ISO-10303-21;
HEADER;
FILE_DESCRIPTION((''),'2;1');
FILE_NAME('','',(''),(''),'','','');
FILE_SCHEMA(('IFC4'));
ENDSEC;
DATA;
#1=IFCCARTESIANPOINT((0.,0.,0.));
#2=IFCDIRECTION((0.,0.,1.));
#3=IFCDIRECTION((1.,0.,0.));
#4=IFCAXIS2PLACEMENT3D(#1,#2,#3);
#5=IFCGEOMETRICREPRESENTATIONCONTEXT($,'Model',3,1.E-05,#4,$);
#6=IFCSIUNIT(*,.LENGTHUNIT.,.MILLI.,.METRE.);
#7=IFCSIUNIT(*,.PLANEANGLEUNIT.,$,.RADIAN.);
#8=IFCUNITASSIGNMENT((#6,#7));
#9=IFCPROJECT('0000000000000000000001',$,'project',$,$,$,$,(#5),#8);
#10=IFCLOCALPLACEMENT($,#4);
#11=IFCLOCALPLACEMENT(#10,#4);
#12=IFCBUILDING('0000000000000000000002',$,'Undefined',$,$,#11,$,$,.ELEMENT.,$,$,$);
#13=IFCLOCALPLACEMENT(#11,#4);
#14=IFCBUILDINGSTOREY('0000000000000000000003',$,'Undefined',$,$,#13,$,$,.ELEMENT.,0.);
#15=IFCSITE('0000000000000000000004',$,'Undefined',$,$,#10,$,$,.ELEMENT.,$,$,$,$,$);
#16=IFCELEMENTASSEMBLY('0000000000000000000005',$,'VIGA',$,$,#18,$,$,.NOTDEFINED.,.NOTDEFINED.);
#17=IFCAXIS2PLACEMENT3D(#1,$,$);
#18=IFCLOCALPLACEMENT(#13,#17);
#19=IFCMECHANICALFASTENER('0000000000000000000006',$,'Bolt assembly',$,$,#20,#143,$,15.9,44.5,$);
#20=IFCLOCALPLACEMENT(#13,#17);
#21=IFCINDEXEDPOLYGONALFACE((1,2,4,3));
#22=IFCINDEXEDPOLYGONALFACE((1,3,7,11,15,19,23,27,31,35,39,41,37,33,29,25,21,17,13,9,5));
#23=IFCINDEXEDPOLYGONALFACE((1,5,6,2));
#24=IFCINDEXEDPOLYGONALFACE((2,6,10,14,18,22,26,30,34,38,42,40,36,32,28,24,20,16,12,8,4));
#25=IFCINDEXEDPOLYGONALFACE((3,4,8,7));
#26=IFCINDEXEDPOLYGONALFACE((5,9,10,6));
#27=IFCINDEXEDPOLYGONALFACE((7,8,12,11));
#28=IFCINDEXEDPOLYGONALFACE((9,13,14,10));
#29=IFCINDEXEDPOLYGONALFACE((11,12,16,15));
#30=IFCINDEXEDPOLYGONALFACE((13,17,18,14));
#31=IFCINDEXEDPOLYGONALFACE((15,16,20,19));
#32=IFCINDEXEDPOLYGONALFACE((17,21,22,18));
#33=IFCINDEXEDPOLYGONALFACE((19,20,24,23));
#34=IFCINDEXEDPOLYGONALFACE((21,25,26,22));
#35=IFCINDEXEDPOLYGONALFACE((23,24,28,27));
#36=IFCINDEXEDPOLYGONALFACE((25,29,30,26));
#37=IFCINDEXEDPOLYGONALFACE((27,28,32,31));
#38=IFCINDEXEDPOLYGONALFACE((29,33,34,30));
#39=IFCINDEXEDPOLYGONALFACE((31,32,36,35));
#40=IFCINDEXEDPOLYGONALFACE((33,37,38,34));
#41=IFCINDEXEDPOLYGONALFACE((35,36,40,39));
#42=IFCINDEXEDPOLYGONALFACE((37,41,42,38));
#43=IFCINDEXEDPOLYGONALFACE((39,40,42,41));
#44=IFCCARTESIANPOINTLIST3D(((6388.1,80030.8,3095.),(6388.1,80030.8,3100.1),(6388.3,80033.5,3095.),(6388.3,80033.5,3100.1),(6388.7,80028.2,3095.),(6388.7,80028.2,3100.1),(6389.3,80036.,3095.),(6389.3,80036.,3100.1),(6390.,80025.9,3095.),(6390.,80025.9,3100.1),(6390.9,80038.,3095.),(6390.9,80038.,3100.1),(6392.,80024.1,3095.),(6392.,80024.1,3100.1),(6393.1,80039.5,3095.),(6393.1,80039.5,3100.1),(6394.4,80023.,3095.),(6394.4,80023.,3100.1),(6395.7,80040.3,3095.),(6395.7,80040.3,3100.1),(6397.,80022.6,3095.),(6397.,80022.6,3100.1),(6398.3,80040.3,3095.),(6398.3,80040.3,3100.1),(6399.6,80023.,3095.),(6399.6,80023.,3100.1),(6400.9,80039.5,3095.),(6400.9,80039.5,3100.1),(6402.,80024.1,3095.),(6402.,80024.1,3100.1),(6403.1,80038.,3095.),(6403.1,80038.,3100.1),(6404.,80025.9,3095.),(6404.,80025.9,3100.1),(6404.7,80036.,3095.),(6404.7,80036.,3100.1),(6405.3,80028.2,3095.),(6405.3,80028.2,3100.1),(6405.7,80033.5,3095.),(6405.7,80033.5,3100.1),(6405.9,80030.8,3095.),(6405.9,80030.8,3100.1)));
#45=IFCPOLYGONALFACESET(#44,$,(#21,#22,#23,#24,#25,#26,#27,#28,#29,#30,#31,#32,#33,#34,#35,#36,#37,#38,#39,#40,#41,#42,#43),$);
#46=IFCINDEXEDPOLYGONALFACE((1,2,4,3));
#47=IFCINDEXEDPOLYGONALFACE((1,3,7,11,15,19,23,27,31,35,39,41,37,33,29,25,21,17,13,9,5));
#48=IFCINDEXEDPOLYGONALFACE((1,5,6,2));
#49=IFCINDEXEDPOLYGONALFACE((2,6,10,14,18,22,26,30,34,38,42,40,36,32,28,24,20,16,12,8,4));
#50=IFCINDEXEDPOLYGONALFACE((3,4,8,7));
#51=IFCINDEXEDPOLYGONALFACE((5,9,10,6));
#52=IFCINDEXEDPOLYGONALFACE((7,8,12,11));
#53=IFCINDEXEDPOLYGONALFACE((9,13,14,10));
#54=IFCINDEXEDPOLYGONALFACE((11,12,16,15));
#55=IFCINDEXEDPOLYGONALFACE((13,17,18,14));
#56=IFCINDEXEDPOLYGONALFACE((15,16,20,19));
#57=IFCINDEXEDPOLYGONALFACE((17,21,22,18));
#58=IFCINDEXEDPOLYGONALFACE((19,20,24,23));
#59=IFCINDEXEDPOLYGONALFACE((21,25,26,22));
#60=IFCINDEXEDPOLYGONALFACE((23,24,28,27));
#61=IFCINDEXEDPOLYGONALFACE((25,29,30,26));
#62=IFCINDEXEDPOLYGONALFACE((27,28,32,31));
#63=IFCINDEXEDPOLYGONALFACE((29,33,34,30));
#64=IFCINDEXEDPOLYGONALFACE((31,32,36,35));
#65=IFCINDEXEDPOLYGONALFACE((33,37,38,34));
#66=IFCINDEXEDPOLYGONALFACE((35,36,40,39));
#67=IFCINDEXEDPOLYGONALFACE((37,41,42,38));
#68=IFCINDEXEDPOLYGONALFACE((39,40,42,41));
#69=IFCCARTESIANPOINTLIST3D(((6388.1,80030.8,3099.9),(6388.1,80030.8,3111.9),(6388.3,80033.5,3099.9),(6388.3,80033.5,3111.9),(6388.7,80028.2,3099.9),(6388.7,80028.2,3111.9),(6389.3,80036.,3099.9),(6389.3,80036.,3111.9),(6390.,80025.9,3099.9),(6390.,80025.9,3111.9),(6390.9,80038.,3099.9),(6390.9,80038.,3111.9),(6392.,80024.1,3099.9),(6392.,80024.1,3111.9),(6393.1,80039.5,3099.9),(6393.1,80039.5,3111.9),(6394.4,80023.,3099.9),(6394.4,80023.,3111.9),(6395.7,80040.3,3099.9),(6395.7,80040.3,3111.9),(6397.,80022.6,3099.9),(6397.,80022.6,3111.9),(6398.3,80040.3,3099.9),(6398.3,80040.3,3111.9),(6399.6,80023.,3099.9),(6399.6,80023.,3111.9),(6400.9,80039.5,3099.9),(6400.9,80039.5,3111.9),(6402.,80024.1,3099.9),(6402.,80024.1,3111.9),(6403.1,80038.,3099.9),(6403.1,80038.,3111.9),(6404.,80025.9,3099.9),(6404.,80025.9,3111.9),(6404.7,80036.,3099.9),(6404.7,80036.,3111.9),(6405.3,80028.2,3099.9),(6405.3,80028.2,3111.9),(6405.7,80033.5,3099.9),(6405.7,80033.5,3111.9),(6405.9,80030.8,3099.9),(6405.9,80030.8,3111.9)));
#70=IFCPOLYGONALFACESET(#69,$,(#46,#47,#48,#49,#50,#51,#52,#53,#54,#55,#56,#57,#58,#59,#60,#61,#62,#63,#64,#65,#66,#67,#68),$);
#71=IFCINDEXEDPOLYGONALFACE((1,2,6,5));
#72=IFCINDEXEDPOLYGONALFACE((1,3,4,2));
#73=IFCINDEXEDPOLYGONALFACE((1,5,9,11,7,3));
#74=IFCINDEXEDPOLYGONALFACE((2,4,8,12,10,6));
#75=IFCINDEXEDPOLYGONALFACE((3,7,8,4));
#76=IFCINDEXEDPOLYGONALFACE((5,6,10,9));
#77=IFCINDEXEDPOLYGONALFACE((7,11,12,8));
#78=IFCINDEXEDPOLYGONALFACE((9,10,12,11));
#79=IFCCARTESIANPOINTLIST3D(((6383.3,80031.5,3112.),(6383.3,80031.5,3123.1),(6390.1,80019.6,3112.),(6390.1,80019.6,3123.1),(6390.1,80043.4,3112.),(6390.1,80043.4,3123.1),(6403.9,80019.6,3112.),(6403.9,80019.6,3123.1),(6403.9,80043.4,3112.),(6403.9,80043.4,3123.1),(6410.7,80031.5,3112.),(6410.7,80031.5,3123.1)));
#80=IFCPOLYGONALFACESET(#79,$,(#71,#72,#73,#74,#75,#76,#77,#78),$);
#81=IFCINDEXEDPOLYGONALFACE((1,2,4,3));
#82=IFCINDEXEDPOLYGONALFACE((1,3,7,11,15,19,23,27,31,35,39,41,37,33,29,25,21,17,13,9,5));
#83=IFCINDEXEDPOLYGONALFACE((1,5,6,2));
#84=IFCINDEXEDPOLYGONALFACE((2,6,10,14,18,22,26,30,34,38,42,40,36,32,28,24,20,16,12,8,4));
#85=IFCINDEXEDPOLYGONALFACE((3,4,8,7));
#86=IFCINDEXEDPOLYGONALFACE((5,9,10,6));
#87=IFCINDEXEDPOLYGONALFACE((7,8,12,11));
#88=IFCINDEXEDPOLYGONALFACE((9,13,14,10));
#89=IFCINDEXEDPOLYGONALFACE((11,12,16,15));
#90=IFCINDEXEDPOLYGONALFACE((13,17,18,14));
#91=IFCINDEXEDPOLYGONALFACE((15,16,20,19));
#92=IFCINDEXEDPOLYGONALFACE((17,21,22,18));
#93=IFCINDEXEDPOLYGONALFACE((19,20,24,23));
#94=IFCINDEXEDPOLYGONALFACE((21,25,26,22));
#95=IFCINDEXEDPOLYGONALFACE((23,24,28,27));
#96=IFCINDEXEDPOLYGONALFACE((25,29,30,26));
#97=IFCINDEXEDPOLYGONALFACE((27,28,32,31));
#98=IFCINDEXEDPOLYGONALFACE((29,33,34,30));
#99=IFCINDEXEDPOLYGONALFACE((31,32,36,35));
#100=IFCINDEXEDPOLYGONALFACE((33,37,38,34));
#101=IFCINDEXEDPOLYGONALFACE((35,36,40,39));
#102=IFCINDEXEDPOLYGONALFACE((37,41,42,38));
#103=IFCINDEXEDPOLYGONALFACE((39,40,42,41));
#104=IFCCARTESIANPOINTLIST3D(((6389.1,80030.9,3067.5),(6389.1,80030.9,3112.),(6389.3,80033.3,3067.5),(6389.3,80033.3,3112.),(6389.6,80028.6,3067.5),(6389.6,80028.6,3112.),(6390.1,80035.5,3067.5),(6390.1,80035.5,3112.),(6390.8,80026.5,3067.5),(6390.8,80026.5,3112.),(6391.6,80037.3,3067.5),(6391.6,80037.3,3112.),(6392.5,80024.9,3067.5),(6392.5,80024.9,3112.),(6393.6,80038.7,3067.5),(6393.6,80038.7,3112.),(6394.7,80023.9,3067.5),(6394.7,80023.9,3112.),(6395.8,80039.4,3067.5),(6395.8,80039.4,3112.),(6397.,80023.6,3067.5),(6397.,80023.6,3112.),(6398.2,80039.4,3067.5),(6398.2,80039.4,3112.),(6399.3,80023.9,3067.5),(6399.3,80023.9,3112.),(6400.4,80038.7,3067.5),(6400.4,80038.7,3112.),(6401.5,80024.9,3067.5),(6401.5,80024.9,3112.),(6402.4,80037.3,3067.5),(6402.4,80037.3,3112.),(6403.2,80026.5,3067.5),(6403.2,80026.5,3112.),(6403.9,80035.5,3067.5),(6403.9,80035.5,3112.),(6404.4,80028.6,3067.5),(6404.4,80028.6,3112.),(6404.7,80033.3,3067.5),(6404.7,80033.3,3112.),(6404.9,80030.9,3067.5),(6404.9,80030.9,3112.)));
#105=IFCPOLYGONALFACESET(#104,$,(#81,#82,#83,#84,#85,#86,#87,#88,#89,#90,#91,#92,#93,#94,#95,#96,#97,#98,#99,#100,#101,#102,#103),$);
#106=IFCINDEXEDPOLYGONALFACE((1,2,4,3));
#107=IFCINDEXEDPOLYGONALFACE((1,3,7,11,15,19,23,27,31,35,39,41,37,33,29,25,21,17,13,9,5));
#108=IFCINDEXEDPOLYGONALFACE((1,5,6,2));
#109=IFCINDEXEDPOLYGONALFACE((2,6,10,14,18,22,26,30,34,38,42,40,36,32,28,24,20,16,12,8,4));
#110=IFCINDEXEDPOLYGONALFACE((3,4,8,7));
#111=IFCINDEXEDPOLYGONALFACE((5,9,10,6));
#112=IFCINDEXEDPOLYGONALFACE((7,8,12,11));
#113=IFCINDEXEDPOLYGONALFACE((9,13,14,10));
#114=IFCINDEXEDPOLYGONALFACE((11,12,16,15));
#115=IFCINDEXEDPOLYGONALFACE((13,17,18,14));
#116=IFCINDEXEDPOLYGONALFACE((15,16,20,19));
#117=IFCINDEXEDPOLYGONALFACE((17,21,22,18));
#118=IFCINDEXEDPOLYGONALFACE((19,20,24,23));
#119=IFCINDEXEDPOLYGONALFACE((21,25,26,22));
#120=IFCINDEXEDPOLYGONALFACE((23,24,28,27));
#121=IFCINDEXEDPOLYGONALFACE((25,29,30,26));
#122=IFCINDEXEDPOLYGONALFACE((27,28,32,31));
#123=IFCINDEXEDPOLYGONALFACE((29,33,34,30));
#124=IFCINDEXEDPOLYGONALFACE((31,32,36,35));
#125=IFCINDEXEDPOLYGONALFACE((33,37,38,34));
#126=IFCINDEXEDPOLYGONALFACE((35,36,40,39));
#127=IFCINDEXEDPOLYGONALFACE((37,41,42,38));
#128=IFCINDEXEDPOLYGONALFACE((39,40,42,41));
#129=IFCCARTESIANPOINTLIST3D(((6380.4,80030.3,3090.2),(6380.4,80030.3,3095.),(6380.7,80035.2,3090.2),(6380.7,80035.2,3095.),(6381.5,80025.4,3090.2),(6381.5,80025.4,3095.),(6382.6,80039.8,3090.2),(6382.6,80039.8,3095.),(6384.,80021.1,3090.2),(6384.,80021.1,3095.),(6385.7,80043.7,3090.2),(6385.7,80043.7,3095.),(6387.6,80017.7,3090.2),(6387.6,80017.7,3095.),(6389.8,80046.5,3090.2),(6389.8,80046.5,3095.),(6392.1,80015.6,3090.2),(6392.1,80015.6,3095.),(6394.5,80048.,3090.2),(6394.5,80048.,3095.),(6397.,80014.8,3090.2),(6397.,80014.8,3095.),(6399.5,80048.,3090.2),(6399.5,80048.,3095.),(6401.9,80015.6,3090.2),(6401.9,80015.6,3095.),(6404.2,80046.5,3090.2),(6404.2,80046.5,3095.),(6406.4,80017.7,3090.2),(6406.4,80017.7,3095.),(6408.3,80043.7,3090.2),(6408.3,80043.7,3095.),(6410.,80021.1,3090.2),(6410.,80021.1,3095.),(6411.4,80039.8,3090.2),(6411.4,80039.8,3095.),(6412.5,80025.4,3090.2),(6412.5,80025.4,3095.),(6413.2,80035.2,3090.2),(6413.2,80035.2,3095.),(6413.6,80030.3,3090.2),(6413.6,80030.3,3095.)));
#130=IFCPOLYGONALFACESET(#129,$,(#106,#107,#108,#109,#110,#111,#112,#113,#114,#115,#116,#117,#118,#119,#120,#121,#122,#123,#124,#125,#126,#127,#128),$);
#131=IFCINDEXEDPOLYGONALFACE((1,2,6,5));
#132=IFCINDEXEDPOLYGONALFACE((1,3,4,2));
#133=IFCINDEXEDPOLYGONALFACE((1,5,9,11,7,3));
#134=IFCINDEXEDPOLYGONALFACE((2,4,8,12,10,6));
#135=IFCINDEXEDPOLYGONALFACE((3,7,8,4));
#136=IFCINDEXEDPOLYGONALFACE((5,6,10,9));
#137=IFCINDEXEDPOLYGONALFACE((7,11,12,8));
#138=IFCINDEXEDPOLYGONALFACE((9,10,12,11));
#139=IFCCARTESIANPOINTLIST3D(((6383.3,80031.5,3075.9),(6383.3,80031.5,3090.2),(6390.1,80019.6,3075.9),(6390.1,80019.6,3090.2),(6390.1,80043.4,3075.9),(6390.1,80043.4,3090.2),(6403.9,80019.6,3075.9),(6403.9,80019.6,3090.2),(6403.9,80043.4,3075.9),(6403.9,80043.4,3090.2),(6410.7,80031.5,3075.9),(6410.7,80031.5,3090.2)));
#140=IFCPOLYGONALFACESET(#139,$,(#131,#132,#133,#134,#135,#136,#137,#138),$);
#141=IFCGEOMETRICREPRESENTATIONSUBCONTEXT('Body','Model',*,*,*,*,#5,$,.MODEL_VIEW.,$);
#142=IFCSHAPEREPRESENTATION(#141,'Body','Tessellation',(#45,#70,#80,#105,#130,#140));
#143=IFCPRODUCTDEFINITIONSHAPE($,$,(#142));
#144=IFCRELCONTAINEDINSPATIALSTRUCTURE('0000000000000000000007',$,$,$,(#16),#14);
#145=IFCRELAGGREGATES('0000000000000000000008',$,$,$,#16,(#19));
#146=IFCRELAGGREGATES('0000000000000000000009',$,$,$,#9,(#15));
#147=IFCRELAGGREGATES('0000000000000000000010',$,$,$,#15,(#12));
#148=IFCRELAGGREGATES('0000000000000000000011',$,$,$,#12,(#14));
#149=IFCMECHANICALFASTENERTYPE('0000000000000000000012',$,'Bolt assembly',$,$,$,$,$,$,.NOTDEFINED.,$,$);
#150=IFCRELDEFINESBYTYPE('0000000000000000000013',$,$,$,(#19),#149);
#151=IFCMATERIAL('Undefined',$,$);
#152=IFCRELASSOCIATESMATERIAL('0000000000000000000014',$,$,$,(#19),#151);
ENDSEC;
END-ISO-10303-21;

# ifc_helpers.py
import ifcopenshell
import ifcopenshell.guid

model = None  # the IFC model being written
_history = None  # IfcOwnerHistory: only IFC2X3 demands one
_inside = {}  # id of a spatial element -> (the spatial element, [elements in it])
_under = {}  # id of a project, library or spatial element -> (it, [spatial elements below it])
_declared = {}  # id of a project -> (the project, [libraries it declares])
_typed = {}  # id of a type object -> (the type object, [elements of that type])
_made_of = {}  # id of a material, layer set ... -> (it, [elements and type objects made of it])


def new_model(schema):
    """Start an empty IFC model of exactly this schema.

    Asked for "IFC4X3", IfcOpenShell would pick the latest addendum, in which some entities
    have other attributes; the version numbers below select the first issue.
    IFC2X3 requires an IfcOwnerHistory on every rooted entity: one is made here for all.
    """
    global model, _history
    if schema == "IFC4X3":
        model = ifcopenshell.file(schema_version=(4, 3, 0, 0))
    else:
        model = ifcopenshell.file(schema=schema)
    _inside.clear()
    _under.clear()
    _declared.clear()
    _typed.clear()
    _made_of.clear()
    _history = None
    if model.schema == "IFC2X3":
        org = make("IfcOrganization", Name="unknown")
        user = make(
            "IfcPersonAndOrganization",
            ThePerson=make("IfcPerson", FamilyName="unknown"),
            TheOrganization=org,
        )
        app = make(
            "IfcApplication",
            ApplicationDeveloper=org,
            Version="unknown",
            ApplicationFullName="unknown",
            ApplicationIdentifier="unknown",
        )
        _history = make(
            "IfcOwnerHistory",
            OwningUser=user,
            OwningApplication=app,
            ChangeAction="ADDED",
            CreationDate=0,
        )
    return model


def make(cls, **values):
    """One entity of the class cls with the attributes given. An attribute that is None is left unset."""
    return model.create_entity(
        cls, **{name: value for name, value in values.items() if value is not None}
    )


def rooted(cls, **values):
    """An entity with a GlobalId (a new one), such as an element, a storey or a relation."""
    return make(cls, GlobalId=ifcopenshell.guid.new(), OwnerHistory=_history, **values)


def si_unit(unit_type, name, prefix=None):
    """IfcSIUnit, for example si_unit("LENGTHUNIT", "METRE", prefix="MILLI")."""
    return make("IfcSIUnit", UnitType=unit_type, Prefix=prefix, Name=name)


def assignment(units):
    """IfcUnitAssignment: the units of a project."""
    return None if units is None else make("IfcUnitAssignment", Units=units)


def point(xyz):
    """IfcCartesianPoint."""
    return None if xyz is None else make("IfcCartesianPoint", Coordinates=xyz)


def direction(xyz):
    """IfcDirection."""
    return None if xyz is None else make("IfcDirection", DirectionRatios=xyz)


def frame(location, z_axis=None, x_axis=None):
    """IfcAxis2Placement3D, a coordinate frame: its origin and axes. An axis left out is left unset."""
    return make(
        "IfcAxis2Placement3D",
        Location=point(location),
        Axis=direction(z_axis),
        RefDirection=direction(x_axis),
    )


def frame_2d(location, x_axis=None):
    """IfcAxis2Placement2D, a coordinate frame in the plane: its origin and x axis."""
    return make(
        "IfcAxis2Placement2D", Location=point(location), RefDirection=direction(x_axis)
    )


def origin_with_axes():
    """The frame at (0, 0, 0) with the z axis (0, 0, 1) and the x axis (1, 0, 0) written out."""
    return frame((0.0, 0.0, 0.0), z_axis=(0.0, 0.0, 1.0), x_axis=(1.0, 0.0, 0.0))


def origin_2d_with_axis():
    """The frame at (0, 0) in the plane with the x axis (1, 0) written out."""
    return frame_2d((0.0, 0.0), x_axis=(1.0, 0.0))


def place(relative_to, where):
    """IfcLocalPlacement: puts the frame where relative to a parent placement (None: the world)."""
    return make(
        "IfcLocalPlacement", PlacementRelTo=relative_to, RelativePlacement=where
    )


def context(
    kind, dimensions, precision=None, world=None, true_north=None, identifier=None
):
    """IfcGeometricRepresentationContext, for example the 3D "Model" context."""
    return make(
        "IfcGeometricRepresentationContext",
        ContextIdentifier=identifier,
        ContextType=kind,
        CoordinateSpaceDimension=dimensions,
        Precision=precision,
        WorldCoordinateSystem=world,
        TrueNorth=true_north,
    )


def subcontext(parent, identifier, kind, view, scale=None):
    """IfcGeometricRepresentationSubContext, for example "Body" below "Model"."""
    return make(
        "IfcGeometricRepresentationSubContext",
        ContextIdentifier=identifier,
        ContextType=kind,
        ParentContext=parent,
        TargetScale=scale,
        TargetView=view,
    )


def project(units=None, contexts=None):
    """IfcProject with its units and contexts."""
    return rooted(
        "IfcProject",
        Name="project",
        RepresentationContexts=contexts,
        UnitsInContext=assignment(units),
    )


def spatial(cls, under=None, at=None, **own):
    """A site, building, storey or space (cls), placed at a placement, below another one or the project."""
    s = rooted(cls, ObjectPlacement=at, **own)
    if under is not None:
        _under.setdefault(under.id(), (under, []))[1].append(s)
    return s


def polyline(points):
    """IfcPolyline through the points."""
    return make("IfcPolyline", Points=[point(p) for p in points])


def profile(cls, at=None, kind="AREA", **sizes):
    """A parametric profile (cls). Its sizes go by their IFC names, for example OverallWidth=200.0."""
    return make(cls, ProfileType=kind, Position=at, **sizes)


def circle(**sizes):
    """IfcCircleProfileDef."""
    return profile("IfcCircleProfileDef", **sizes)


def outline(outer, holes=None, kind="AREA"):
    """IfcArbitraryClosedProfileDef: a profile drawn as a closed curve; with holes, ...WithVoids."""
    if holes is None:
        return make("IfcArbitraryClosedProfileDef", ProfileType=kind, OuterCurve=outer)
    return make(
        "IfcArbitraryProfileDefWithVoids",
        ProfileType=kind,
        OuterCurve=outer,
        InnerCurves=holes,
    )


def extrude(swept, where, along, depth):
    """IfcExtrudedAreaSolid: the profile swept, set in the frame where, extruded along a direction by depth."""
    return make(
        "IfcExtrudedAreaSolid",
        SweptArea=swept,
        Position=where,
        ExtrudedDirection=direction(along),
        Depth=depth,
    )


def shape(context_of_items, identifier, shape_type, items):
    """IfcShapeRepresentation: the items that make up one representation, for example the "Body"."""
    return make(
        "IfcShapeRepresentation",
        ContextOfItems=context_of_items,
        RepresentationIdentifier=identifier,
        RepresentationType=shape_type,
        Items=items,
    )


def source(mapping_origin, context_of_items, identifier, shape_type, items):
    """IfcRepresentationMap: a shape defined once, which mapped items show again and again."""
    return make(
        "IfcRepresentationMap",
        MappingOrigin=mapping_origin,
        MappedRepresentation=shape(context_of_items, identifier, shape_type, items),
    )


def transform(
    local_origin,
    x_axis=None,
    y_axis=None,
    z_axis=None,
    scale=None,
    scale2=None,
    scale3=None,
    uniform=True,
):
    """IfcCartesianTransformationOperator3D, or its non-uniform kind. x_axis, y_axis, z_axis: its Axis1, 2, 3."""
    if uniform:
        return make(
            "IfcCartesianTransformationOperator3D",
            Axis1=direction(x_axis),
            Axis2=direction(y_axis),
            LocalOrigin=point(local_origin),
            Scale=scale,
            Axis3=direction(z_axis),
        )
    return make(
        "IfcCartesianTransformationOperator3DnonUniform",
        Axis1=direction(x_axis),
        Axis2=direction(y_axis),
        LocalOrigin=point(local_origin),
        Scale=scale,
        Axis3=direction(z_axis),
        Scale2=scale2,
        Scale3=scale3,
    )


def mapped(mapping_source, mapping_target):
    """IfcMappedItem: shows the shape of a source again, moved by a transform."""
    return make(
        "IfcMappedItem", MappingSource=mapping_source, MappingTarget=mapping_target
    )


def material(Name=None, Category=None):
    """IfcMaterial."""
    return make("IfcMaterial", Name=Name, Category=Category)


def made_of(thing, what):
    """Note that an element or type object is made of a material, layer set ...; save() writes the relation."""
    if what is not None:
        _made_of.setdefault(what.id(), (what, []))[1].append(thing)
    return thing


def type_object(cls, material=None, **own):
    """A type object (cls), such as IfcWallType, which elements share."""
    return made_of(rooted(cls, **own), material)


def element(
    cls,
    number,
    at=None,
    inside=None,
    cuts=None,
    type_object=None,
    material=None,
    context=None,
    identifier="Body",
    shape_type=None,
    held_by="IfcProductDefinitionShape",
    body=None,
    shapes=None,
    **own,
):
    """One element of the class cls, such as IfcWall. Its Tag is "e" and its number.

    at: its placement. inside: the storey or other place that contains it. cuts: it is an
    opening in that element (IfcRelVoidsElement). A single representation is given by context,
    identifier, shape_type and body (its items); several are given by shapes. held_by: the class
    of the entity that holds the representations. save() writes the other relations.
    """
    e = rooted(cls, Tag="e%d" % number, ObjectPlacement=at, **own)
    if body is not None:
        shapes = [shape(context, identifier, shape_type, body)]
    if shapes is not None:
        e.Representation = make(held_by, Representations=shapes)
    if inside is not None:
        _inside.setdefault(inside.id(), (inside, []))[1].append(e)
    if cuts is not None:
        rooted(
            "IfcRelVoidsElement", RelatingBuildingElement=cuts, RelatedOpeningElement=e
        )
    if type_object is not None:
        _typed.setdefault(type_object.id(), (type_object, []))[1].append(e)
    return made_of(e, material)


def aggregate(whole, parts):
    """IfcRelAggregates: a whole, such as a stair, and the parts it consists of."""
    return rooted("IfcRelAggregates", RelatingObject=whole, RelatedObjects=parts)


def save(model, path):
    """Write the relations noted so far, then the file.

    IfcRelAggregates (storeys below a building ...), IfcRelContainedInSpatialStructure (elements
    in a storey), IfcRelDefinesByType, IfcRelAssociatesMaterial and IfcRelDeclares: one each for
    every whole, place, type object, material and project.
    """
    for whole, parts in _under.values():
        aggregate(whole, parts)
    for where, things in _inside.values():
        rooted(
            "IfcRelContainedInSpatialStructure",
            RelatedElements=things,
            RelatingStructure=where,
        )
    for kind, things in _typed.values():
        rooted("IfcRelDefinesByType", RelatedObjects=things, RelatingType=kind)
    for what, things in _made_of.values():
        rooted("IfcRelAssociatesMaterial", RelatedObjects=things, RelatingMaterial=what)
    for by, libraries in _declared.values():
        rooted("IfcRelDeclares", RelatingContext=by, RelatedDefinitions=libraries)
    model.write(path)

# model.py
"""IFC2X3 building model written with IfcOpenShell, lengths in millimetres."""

from ifc_helpers import new_model, si_unit, frame, origin_with_axes, origin_2d_with_axis, place, context, subcontext, project, spatial, polyline, circle, outline, extrude, source, transform, mapped, material, type_object, element, aggregate, save


model = new_model("IFC2X3")

# Units and contexts
model_context = context("Model", 3, precision=1e-05, world=origin_with_axes())
body_context = subcontext(model_context, "Body", "Model", "MODEL_VIEW")
ifc_project = project(units=[si_unit("LENGTHUNIT", "METRE", prefix="MILLI"), si_unit("PLANEANGLEUNIT", "RADIAN")], contexts=[model_context])

# Site, building, storey
site_placement = place(None, origin_with_axes())
site = spatial("IfcSite", under=ifc_project, at=site_placement, Name="Undefined", CompositionType="ELEMENT")
building_placement = place(site_placement, origin_with_axes())
building = spatial("IfcBuilding", under=site, at=building_placement, Name="Undefined", CompositionType="ELEMENT")
storey_placement = place(building_placement, origin_with_axes())
storey = spatial("IfcBuildingStorey", under=building, at=storey_placement, Name="Undefined", CompositionType="ELEMENT", Elevation=0.0)

# Element assembly
assembly_1_placement = place(storey_placement, origin_with_axes())
assembly_1 = element("IfcElementAssembly", 1, at=assembly_1_placement, inside=storey, Name="VIGA", AssemblyPlace="NOTDEFINED", PredefinedType="NOTDEFINED")

# Mechanical fastener
ifc_material_1 = material(Name="Undefined")
mechanical_fastener_type = type_object("IfcMechanicalFastenerType", Name="Bolt assembly")
shared_shape_1 = source(origin_with_axes(), body_context, "Body", "SweptSolid", [
    extrude(circle(Radius=8.9, at=origin_2d_with_axis()), frame((0.0, -0.1, 0.0), z_axis=(0.0, 1.0, 0.0), x_axis=(1.0, 0.0, 0.0)), (0.0, 0.0, 1.0), 5.1),
    extrude(circle(Radius=8.9, at=origin_2d_with_axis()), frame((0.0, -11.9, 0.0), z_axis=(0.0, 1.0, 0.0), x_axis=(1.0, 0.0, 0.0)), (0.0, 0.0, 1.0), 12.0),
    extrude(outline(polyline([(11.9, -6.9), (11.9, 6.9), (0.0, 13.7), (-11.9, 6.9), (-11.9, -6.9), (0.0, -13.7), (11.9, -6.9)])), frame((0.0, -23.1, 0.0), z_axis=(0.0, 1.0, 0.0), x_axis=(1.0, 0.0, 0.0)), (0.0, 0.0, 1.0), 11.1),
    extrude(circle(Radius=7.9, at=origin_2d_with_axis()), frame((0.0, -12.0, 0.0), z_axis=(0.0, 1.0, 0.0), x_axis=(1.0, 0.0, 0.0)), (0.0, 0.0, 1.0), 44.5),
    extrude(circle(Radius=16.7, at=origin_2d_with_axis()), frame((0.0, 5.0, 0.0), z_axis=(0.0, 1.0, 0.0), x_axis=(1.0, 0.0, 0.0)), (0.0, 0.0, 1.0), 4.8),
    extrude(outline(polyline([(11.9, -6.9), (11.9, 6.9), (0.0, 13.7), (-11.9, 6.9), (-11.9, -6.9), (0.0, -13.7), (11.9, -6.9)])), frame((0.0, 9.8, 0.0), z_axis=(0.0, 1.0, 0.0), x_axis=(1.0, 0.0, 0.0)), (0.0, 0.0, 1.0), 14.3),
])
mechanical_fastener_1_placement = place(assembly_1_placement, frame((6397.0, 80031.5, 3100.0), z_axis=(1.0, 0.000006, 0.0), x_axis=(0.000006, -1.0, 0.0)))
mechanical_fastener_1 = element("IfcMechanicalFastener", 2, at=mechanical_fastener_1_placement, type_object=mechanical_fastener_type, material=ifc_material_1, Name="Bolt assembly", NominalDiameter=15.9, NominalLength=44.5, context=body_context, shape_type="MappedRepresentation", body=[
    mapped(shared_shape_1, transform((0.0, 0.0, 0.0))),
])
aggregate(assembly_1, [mechanical_fastener_1])

save(model, "model.ifc")
